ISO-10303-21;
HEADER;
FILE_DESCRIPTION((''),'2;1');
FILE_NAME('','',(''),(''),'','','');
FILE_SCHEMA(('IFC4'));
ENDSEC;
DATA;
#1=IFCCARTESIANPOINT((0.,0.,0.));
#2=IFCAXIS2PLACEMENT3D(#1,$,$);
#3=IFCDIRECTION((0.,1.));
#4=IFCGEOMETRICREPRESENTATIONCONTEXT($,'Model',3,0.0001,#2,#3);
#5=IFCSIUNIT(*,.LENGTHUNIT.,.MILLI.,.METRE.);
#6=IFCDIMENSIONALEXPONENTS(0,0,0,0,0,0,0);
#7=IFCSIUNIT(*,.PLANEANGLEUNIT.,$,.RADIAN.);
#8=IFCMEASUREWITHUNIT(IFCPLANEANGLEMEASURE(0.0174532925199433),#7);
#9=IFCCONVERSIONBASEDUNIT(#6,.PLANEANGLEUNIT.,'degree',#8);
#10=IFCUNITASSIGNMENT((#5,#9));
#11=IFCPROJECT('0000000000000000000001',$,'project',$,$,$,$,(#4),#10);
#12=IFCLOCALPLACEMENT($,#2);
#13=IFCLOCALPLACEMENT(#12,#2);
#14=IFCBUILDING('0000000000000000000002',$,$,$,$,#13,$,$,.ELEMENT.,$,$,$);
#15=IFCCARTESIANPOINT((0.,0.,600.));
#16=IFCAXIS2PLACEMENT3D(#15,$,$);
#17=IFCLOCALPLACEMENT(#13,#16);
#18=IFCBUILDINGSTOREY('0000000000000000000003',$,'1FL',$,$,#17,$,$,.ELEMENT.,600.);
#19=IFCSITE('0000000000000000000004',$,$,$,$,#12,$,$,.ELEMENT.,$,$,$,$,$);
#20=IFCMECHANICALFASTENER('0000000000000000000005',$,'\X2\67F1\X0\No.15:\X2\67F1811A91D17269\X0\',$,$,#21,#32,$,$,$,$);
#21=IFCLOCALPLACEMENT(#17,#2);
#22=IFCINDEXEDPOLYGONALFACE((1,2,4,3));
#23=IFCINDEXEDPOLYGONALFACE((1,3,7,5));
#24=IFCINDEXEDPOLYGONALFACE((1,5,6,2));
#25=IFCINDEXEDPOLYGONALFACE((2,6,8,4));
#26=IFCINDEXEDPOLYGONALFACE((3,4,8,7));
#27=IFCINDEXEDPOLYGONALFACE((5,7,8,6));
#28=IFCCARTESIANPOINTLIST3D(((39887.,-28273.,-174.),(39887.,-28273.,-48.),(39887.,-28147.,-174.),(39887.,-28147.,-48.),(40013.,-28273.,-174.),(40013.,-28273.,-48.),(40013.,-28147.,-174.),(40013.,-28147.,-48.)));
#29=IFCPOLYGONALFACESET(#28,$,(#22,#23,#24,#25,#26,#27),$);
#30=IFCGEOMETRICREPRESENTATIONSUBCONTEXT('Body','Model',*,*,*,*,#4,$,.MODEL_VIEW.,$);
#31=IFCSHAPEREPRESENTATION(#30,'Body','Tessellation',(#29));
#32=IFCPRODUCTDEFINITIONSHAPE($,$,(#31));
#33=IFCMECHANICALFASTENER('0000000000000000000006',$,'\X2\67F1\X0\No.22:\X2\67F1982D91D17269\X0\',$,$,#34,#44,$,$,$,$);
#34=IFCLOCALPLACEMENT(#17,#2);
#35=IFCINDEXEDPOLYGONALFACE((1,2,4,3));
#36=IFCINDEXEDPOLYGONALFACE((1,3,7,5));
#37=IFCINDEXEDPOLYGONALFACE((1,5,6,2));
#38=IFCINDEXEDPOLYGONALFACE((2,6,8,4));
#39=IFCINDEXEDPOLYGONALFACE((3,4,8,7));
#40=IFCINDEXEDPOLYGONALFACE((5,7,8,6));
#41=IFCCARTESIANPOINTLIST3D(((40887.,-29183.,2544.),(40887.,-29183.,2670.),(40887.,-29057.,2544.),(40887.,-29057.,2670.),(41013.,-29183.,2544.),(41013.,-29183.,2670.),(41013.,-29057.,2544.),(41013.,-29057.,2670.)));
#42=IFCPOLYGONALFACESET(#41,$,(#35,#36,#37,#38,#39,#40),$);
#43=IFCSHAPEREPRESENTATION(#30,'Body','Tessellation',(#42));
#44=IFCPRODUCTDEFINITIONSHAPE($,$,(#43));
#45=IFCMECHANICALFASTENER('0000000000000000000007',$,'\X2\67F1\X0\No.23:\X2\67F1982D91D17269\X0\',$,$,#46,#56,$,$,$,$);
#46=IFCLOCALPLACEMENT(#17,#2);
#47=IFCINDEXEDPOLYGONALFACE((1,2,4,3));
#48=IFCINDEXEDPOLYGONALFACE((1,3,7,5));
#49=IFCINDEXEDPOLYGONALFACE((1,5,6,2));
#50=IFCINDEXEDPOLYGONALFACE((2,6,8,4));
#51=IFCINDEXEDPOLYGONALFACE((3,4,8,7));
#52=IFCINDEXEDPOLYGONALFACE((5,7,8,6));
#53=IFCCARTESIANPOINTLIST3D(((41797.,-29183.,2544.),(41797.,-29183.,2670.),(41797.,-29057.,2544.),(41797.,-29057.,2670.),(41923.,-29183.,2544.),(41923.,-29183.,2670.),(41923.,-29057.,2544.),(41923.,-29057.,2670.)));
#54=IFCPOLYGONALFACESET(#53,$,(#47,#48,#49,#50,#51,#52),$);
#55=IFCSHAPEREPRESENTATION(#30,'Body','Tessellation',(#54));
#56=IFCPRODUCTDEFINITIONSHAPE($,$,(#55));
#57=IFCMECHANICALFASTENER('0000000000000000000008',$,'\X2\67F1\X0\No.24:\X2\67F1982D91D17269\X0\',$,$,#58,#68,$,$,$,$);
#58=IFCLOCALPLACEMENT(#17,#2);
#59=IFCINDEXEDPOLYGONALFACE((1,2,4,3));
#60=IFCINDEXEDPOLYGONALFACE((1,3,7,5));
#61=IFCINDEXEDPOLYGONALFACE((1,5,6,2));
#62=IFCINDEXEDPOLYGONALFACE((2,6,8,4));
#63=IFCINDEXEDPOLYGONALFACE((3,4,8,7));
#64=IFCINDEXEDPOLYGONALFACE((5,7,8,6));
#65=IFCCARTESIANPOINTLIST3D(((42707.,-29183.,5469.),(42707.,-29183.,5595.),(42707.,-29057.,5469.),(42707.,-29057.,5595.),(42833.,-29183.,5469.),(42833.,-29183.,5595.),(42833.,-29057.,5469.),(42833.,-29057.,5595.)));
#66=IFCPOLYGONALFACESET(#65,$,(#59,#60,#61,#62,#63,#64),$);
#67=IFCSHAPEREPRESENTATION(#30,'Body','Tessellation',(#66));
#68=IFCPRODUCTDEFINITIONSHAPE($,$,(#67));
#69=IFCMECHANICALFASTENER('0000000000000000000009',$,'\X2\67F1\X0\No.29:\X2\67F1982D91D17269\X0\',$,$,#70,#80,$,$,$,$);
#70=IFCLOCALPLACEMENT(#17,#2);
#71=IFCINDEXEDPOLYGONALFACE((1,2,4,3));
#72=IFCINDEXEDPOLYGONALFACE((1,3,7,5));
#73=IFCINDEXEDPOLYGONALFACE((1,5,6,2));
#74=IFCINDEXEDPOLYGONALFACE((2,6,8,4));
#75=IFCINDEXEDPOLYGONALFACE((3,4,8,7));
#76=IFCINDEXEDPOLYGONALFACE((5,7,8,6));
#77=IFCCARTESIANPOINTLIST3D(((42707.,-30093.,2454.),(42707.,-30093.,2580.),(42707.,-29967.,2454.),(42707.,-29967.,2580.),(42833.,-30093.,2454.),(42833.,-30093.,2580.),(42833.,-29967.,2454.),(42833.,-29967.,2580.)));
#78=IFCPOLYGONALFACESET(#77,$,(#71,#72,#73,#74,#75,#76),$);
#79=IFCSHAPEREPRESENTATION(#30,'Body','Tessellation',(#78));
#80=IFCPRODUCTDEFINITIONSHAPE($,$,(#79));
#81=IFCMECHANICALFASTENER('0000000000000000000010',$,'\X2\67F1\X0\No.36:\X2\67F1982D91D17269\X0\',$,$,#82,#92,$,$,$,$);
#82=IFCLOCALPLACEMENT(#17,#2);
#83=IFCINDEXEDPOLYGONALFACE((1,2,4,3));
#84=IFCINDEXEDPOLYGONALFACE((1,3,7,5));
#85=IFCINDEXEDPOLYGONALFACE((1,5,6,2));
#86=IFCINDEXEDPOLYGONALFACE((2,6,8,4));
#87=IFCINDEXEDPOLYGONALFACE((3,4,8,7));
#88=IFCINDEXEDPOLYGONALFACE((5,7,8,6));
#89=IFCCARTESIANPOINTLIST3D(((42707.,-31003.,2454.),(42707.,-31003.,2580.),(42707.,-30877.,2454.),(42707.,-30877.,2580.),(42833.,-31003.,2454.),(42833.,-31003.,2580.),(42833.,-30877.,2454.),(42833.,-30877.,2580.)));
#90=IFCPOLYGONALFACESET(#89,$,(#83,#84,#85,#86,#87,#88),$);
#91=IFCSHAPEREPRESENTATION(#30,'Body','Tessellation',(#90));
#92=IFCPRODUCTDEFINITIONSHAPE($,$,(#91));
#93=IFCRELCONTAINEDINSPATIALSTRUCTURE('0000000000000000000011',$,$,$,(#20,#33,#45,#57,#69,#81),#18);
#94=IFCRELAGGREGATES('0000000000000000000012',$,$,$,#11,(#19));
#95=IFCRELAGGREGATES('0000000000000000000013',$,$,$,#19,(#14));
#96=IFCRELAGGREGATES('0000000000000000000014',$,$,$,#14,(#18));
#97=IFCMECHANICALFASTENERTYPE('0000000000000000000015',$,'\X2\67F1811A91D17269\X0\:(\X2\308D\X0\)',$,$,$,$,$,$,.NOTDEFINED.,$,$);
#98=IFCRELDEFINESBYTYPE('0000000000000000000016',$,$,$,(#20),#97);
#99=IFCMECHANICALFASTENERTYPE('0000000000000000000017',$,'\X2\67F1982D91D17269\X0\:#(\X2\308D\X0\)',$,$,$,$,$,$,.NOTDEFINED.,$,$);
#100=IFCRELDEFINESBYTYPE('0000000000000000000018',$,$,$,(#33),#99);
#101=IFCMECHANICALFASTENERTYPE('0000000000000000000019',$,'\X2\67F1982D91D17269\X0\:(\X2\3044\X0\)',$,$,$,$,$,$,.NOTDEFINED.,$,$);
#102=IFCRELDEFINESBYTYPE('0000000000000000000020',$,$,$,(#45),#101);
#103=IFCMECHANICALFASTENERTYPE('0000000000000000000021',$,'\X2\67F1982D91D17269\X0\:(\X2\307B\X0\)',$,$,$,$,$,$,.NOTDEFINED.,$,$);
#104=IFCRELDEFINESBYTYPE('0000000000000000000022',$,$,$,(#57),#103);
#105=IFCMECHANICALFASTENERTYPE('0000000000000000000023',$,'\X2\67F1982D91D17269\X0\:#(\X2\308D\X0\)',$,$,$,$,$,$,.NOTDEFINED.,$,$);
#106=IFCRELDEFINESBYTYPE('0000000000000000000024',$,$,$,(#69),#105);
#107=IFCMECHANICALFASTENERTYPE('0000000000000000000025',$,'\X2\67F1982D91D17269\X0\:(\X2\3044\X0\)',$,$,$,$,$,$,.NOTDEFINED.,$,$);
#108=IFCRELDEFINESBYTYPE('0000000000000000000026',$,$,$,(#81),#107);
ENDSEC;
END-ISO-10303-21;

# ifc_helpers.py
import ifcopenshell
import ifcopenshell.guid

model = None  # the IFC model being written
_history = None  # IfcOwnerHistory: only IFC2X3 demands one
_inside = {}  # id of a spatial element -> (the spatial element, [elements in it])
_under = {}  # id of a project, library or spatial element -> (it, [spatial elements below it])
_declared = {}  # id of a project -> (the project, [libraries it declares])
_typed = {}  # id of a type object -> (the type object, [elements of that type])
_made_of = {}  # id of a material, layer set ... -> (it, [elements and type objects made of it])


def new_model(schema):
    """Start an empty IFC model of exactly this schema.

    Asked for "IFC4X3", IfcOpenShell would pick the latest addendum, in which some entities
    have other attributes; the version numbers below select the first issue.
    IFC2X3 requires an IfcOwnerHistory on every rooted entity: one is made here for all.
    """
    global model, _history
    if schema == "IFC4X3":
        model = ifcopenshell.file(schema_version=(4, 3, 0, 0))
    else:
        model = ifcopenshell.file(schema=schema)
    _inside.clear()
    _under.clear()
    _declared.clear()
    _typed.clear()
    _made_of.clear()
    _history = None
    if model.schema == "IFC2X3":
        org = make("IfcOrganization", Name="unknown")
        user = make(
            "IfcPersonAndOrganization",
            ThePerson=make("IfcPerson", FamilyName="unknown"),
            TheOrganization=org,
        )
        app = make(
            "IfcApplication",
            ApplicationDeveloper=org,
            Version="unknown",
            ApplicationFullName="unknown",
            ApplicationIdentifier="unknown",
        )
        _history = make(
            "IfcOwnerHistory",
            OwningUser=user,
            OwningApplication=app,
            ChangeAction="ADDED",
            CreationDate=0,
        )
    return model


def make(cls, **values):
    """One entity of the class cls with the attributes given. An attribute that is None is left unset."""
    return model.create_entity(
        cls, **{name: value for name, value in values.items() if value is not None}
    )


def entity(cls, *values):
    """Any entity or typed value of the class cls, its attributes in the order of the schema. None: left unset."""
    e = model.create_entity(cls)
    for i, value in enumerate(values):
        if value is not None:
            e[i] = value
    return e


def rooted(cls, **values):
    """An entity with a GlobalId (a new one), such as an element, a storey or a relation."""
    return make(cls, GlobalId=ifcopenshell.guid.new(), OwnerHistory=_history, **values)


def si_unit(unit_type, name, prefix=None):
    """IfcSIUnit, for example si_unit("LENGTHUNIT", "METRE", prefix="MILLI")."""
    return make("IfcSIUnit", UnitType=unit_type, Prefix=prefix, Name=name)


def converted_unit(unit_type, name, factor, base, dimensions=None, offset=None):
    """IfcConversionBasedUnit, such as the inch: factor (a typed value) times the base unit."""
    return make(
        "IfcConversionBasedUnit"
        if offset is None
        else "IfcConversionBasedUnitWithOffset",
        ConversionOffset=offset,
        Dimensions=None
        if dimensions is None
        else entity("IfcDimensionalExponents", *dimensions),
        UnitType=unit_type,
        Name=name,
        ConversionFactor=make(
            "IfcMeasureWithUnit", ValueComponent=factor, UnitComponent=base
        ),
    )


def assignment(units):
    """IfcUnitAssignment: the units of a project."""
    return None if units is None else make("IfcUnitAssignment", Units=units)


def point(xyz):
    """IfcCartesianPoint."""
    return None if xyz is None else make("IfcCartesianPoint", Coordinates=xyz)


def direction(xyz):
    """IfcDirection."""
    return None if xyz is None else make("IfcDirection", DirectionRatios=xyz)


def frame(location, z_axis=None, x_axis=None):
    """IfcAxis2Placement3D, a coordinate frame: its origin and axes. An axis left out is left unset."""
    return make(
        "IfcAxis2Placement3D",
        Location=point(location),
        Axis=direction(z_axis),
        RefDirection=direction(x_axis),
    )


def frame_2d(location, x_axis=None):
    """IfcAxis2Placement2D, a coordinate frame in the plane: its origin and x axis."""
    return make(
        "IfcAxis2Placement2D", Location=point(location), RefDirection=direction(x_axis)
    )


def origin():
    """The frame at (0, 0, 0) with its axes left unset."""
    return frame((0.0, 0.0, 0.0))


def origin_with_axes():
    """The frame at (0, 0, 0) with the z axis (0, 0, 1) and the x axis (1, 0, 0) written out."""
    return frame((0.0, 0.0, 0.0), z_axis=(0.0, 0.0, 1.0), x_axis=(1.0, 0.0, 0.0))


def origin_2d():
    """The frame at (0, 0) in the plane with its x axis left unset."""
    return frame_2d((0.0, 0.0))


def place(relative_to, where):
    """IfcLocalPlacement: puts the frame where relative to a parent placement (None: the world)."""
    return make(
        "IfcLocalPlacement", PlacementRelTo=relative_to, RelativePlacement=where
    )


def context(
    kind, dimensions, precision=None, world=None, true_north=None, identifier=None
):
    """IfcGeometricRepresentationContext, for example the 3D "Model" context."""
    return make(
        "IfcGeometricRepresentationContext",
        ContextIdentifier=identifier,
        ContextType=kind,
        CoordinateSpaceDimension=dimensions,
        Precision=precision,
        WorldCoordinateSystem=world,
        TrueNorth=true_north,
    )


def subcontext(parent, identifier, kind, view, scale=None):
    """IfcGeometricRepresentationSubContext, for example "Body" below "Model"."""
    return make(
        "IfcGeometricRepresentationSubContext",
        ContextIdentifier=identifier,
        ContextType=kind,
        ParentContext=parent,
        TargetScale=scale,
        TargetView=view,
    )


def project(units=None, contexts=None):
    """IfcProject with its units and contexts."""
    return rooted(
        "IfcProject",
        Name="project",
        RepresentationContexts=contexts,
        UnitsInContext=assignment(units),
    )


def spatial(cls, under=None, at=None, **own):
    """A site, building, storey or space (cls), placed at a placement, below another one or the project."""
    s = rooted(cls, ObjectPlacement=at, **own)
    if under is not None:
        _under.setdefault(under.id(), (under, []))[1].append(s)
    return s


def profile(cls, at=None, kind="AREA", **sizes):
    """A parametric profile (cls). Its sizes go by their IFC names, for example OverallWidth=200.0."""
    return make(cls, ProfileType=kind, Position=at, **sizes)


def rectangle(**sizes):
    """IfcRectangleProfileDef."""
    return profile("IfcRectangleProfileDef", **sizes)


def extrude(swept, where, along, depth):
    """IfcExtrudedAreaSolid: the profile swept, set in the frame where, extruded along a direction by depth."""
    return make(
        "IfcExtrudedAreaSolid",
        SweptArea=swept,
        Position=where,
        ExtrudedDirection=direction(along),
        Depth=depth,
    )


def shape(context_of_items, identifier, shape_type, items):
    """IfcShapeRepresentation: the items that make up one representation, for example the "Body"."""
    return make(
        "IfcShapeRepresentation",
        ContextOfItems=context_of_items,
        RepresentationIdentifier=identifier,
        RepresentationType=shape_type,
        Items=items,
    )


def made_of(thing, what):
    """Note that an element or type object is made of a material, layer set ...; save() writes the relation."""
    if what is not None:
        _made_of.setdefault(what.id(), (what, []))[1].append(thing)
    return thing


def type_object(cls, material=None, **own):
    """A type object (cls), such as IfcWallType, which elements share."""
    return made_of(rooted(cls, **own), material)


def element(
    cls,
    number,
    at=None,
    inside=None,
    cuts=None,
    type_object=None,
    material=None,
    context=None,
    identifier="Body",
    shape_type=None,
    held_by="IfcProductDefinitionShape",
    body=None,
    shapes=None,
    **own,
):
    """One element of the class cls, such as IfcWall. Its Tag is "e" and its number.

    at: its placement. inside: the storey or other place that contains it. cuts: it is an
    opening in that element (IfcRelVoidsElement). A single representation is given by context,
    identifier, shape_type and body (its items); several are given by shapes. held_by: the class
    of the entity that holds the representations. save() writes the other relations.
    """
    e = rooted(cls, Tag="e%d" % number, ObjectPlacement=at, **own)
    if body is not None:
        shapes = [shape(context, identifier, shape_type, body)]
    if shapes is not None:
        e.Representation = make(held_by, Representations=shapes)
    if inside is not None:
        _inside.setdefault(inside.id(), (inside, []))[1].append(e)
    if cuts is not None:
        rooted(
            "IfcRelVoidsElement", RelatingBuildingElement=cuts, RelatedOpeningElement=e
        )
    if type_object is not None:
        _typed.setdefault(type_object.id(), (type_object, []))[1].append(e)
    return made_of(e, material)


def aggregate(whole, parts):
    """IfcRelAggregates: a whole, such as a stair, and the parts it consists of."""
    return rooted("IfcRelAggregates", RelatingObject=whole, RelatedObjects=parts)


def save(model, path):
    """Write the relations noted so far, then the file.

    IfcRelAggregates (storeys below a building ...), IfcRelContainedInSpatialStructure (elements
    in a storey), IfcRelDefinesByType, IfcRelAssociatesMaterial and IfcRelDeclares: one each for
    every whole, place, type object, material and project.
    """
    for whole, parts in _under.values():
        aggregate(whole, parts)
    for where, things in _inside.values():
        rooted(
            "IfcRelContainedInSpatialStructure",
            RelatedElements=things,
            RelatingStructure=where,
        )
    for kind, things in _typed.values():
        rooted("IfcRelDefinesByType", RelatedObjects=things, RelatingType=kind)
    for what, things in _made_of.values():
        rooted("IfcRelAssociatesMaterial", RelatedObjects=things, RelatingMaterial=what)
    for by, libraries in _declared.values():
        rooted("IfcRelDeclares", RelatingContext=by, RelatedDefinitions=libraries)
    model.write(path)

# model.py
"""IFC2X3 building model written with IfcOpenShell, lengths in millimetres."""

from ifc_helpers import new_model, entity, si_unit, converted_unit, direction, frame, origin, origin_with_axes, origin_2d, place, context, subcontext, project, spatial, rectangle, extrude, type_object, element, save


model = new_model("IFC2X3")

# Units and contexts
model_context = context("Model", 3, precision=0.0001, world=origin(), true_north=direction((0.0, 1.0)))
body_context = subcontext(model_context, "Body", "Model", "MODEL_VIEW")
ifc_project = project(units=[si_unit("LENGTHUNIT", "METRE", prefix="MILLI"), converted_unit("PLANEANGLEUNIT", "degree", entity("IfcPlaneAngleMeasure", 0.0174532925199433), si_unit("PLANEANGLEUNIT", "RADIAN"), dimensions=[0, 0, 0, 0, 0, 0, 0])], contexts=[model_context])

# Site, building, storey
site_placement = place(None, origin())
site = spatial("IfcSite", under=ifc_project, at=site_placement, CompositionType="ELEMENT")
building_placement = place(site_placement, origin())
building = spatial("IfcBuilding", under=site, at=building_placement, CompositionType="ELEMENT")
storey_placement = place(building_placement, frame((0.0, 0.0, 600.0)))
storey = spatial("IfcBuildingStorey", under=building, at=storey_placement, Name="1FL", CompositionType="ELEMENT", Elevation=600.0)

# Mechanical fasteners
mechanical_fastener_type_1 = type_object("IfcMechanicalFastenerType", Name="柱脚金物:(ろ)")
mechanical_fastener_1_placement = place(storey_placement, frame((39950.0, -28210.0, -174.0)))
element("IfcMechanicalFastener", 1, at=mechanical_fastener_1_placement, inside=storey, type_object=mechanical_fastener_type_1, Name="柱No.15:柱脚金物", context=body_context, shape_type="SweptSolid", body=[
    extrude(rectangle(XDim=126.0, YDim=126.0, at=origin_2d()), origin_with_axes(), (0.0, 0.0, 1.0), 126.0),
])
mechanical_fastener_type_2 = type_object("IfcMechanicalFastenerType", Name="柱頭金物:#(ろ)")
mechanical_fastener_2_placement = place(storey_placement, frame((40950.0, -29120.0, 2544.0)))
element("IfcMechanicalFastener", 2, at=mechanical_fastener_2_placement, inside=storey, type_object=mechanical_fastener_type_2, Name="柱No.22:柱頭金物", context=body_context, shape_type="SweptSolid", body=[
    extrude(rectangle(XDim=126.0, YDim=126.0, at=origin_2d()), origin_with_axes(), (0.0, 0.0, 1.0), 126.0),
])
mechanical_fastener_type_3 = type_object("IfcMechanicalFastenerType", Name="柱頭金物:(い)")
mechanical_fastener_3_placement = place(storey_placement, frame((41860.0, -29120.0, 2544.0)))
element("IfcMechanicalFastener", 3, at=mechanical_fastener_3_placement, inside=storey, type_object=mechanical_fastener_type_3, Name="柱No.23:柱頭金物", context=body_context, shape_type="SweptSolid", body=[
    extrude(rectangle(XDim=126.0, YDim=126.0, at=origin_2d()), origin_with_axes(), (0.0, 0.0, 1.0), 126.0),
])
mechanical_fastener_type_4 = type_object("IfcMechanicalFastenerType", Name="柱頭金物:(ほ)")
mechanical_fastener_4_placement = place(storey_placement, frame((42770.0, -29120.0, 5469.0)))
element("IfcMechanicalFastener", 4, at=mechanical_fastener_4_placement, inside=storey, type_object=mechanical_fastener_type_4, Name="柱No.24:柱頭金物", context=body_context, shape_type="SweptSolid", body=[
    extrude(rectangle(XDim=126.0, YDim=126.0, at=origin_2d()), origin_with_axes(), (0.0, 0.0, 1.0), 126.0),
])
mechanical_fastener_type_5 = type_object("IfcMechanicalFastenerType", Name="柱頭金物:#(ろ)")
mechanical_fastener_5_placement = place(storey_placement, frame((42770.0, -30030.0, 2454.0)))
element("IfcMechanicalFastener", 5, at=mechanical_fastener_5_placement, inside=storey, type_object=mechanical_fastener_type_5, Name="柱No.29:柱頭金物", context=body_context, shape_type="SweptSolid", body=[
    extrude(rectangle(XDim=126.0, YDim=126.0, at=origin_2d()), origin_with_axes(), (0.0, 0.0, 1.0), 126.0),
])
mechanical_fastener_type_6 = type_object("IfcMechanicalFastenerType", Name="柱頭金物:(い)")
mechanical_fastener_6_placement = place(storey_placement, frame((42770.0, -30940.0, 2454.0)))
element("IfcMechanicalFastener", 6, at=mechanical_fastener_6_placement, inside=storey, type_object=mechanical_fastener_type_6, Name="柱No.36:柱頭金物", context=body_context, shape_type="SweptSolid", body=[
    extrude(rectangle(XDim=126.0, YDim=126.0, at=origin_2d()), origin_with_axes(), (0.0, 0.0, 1.0), 126.0),
])

save(model, "model.ifc")
